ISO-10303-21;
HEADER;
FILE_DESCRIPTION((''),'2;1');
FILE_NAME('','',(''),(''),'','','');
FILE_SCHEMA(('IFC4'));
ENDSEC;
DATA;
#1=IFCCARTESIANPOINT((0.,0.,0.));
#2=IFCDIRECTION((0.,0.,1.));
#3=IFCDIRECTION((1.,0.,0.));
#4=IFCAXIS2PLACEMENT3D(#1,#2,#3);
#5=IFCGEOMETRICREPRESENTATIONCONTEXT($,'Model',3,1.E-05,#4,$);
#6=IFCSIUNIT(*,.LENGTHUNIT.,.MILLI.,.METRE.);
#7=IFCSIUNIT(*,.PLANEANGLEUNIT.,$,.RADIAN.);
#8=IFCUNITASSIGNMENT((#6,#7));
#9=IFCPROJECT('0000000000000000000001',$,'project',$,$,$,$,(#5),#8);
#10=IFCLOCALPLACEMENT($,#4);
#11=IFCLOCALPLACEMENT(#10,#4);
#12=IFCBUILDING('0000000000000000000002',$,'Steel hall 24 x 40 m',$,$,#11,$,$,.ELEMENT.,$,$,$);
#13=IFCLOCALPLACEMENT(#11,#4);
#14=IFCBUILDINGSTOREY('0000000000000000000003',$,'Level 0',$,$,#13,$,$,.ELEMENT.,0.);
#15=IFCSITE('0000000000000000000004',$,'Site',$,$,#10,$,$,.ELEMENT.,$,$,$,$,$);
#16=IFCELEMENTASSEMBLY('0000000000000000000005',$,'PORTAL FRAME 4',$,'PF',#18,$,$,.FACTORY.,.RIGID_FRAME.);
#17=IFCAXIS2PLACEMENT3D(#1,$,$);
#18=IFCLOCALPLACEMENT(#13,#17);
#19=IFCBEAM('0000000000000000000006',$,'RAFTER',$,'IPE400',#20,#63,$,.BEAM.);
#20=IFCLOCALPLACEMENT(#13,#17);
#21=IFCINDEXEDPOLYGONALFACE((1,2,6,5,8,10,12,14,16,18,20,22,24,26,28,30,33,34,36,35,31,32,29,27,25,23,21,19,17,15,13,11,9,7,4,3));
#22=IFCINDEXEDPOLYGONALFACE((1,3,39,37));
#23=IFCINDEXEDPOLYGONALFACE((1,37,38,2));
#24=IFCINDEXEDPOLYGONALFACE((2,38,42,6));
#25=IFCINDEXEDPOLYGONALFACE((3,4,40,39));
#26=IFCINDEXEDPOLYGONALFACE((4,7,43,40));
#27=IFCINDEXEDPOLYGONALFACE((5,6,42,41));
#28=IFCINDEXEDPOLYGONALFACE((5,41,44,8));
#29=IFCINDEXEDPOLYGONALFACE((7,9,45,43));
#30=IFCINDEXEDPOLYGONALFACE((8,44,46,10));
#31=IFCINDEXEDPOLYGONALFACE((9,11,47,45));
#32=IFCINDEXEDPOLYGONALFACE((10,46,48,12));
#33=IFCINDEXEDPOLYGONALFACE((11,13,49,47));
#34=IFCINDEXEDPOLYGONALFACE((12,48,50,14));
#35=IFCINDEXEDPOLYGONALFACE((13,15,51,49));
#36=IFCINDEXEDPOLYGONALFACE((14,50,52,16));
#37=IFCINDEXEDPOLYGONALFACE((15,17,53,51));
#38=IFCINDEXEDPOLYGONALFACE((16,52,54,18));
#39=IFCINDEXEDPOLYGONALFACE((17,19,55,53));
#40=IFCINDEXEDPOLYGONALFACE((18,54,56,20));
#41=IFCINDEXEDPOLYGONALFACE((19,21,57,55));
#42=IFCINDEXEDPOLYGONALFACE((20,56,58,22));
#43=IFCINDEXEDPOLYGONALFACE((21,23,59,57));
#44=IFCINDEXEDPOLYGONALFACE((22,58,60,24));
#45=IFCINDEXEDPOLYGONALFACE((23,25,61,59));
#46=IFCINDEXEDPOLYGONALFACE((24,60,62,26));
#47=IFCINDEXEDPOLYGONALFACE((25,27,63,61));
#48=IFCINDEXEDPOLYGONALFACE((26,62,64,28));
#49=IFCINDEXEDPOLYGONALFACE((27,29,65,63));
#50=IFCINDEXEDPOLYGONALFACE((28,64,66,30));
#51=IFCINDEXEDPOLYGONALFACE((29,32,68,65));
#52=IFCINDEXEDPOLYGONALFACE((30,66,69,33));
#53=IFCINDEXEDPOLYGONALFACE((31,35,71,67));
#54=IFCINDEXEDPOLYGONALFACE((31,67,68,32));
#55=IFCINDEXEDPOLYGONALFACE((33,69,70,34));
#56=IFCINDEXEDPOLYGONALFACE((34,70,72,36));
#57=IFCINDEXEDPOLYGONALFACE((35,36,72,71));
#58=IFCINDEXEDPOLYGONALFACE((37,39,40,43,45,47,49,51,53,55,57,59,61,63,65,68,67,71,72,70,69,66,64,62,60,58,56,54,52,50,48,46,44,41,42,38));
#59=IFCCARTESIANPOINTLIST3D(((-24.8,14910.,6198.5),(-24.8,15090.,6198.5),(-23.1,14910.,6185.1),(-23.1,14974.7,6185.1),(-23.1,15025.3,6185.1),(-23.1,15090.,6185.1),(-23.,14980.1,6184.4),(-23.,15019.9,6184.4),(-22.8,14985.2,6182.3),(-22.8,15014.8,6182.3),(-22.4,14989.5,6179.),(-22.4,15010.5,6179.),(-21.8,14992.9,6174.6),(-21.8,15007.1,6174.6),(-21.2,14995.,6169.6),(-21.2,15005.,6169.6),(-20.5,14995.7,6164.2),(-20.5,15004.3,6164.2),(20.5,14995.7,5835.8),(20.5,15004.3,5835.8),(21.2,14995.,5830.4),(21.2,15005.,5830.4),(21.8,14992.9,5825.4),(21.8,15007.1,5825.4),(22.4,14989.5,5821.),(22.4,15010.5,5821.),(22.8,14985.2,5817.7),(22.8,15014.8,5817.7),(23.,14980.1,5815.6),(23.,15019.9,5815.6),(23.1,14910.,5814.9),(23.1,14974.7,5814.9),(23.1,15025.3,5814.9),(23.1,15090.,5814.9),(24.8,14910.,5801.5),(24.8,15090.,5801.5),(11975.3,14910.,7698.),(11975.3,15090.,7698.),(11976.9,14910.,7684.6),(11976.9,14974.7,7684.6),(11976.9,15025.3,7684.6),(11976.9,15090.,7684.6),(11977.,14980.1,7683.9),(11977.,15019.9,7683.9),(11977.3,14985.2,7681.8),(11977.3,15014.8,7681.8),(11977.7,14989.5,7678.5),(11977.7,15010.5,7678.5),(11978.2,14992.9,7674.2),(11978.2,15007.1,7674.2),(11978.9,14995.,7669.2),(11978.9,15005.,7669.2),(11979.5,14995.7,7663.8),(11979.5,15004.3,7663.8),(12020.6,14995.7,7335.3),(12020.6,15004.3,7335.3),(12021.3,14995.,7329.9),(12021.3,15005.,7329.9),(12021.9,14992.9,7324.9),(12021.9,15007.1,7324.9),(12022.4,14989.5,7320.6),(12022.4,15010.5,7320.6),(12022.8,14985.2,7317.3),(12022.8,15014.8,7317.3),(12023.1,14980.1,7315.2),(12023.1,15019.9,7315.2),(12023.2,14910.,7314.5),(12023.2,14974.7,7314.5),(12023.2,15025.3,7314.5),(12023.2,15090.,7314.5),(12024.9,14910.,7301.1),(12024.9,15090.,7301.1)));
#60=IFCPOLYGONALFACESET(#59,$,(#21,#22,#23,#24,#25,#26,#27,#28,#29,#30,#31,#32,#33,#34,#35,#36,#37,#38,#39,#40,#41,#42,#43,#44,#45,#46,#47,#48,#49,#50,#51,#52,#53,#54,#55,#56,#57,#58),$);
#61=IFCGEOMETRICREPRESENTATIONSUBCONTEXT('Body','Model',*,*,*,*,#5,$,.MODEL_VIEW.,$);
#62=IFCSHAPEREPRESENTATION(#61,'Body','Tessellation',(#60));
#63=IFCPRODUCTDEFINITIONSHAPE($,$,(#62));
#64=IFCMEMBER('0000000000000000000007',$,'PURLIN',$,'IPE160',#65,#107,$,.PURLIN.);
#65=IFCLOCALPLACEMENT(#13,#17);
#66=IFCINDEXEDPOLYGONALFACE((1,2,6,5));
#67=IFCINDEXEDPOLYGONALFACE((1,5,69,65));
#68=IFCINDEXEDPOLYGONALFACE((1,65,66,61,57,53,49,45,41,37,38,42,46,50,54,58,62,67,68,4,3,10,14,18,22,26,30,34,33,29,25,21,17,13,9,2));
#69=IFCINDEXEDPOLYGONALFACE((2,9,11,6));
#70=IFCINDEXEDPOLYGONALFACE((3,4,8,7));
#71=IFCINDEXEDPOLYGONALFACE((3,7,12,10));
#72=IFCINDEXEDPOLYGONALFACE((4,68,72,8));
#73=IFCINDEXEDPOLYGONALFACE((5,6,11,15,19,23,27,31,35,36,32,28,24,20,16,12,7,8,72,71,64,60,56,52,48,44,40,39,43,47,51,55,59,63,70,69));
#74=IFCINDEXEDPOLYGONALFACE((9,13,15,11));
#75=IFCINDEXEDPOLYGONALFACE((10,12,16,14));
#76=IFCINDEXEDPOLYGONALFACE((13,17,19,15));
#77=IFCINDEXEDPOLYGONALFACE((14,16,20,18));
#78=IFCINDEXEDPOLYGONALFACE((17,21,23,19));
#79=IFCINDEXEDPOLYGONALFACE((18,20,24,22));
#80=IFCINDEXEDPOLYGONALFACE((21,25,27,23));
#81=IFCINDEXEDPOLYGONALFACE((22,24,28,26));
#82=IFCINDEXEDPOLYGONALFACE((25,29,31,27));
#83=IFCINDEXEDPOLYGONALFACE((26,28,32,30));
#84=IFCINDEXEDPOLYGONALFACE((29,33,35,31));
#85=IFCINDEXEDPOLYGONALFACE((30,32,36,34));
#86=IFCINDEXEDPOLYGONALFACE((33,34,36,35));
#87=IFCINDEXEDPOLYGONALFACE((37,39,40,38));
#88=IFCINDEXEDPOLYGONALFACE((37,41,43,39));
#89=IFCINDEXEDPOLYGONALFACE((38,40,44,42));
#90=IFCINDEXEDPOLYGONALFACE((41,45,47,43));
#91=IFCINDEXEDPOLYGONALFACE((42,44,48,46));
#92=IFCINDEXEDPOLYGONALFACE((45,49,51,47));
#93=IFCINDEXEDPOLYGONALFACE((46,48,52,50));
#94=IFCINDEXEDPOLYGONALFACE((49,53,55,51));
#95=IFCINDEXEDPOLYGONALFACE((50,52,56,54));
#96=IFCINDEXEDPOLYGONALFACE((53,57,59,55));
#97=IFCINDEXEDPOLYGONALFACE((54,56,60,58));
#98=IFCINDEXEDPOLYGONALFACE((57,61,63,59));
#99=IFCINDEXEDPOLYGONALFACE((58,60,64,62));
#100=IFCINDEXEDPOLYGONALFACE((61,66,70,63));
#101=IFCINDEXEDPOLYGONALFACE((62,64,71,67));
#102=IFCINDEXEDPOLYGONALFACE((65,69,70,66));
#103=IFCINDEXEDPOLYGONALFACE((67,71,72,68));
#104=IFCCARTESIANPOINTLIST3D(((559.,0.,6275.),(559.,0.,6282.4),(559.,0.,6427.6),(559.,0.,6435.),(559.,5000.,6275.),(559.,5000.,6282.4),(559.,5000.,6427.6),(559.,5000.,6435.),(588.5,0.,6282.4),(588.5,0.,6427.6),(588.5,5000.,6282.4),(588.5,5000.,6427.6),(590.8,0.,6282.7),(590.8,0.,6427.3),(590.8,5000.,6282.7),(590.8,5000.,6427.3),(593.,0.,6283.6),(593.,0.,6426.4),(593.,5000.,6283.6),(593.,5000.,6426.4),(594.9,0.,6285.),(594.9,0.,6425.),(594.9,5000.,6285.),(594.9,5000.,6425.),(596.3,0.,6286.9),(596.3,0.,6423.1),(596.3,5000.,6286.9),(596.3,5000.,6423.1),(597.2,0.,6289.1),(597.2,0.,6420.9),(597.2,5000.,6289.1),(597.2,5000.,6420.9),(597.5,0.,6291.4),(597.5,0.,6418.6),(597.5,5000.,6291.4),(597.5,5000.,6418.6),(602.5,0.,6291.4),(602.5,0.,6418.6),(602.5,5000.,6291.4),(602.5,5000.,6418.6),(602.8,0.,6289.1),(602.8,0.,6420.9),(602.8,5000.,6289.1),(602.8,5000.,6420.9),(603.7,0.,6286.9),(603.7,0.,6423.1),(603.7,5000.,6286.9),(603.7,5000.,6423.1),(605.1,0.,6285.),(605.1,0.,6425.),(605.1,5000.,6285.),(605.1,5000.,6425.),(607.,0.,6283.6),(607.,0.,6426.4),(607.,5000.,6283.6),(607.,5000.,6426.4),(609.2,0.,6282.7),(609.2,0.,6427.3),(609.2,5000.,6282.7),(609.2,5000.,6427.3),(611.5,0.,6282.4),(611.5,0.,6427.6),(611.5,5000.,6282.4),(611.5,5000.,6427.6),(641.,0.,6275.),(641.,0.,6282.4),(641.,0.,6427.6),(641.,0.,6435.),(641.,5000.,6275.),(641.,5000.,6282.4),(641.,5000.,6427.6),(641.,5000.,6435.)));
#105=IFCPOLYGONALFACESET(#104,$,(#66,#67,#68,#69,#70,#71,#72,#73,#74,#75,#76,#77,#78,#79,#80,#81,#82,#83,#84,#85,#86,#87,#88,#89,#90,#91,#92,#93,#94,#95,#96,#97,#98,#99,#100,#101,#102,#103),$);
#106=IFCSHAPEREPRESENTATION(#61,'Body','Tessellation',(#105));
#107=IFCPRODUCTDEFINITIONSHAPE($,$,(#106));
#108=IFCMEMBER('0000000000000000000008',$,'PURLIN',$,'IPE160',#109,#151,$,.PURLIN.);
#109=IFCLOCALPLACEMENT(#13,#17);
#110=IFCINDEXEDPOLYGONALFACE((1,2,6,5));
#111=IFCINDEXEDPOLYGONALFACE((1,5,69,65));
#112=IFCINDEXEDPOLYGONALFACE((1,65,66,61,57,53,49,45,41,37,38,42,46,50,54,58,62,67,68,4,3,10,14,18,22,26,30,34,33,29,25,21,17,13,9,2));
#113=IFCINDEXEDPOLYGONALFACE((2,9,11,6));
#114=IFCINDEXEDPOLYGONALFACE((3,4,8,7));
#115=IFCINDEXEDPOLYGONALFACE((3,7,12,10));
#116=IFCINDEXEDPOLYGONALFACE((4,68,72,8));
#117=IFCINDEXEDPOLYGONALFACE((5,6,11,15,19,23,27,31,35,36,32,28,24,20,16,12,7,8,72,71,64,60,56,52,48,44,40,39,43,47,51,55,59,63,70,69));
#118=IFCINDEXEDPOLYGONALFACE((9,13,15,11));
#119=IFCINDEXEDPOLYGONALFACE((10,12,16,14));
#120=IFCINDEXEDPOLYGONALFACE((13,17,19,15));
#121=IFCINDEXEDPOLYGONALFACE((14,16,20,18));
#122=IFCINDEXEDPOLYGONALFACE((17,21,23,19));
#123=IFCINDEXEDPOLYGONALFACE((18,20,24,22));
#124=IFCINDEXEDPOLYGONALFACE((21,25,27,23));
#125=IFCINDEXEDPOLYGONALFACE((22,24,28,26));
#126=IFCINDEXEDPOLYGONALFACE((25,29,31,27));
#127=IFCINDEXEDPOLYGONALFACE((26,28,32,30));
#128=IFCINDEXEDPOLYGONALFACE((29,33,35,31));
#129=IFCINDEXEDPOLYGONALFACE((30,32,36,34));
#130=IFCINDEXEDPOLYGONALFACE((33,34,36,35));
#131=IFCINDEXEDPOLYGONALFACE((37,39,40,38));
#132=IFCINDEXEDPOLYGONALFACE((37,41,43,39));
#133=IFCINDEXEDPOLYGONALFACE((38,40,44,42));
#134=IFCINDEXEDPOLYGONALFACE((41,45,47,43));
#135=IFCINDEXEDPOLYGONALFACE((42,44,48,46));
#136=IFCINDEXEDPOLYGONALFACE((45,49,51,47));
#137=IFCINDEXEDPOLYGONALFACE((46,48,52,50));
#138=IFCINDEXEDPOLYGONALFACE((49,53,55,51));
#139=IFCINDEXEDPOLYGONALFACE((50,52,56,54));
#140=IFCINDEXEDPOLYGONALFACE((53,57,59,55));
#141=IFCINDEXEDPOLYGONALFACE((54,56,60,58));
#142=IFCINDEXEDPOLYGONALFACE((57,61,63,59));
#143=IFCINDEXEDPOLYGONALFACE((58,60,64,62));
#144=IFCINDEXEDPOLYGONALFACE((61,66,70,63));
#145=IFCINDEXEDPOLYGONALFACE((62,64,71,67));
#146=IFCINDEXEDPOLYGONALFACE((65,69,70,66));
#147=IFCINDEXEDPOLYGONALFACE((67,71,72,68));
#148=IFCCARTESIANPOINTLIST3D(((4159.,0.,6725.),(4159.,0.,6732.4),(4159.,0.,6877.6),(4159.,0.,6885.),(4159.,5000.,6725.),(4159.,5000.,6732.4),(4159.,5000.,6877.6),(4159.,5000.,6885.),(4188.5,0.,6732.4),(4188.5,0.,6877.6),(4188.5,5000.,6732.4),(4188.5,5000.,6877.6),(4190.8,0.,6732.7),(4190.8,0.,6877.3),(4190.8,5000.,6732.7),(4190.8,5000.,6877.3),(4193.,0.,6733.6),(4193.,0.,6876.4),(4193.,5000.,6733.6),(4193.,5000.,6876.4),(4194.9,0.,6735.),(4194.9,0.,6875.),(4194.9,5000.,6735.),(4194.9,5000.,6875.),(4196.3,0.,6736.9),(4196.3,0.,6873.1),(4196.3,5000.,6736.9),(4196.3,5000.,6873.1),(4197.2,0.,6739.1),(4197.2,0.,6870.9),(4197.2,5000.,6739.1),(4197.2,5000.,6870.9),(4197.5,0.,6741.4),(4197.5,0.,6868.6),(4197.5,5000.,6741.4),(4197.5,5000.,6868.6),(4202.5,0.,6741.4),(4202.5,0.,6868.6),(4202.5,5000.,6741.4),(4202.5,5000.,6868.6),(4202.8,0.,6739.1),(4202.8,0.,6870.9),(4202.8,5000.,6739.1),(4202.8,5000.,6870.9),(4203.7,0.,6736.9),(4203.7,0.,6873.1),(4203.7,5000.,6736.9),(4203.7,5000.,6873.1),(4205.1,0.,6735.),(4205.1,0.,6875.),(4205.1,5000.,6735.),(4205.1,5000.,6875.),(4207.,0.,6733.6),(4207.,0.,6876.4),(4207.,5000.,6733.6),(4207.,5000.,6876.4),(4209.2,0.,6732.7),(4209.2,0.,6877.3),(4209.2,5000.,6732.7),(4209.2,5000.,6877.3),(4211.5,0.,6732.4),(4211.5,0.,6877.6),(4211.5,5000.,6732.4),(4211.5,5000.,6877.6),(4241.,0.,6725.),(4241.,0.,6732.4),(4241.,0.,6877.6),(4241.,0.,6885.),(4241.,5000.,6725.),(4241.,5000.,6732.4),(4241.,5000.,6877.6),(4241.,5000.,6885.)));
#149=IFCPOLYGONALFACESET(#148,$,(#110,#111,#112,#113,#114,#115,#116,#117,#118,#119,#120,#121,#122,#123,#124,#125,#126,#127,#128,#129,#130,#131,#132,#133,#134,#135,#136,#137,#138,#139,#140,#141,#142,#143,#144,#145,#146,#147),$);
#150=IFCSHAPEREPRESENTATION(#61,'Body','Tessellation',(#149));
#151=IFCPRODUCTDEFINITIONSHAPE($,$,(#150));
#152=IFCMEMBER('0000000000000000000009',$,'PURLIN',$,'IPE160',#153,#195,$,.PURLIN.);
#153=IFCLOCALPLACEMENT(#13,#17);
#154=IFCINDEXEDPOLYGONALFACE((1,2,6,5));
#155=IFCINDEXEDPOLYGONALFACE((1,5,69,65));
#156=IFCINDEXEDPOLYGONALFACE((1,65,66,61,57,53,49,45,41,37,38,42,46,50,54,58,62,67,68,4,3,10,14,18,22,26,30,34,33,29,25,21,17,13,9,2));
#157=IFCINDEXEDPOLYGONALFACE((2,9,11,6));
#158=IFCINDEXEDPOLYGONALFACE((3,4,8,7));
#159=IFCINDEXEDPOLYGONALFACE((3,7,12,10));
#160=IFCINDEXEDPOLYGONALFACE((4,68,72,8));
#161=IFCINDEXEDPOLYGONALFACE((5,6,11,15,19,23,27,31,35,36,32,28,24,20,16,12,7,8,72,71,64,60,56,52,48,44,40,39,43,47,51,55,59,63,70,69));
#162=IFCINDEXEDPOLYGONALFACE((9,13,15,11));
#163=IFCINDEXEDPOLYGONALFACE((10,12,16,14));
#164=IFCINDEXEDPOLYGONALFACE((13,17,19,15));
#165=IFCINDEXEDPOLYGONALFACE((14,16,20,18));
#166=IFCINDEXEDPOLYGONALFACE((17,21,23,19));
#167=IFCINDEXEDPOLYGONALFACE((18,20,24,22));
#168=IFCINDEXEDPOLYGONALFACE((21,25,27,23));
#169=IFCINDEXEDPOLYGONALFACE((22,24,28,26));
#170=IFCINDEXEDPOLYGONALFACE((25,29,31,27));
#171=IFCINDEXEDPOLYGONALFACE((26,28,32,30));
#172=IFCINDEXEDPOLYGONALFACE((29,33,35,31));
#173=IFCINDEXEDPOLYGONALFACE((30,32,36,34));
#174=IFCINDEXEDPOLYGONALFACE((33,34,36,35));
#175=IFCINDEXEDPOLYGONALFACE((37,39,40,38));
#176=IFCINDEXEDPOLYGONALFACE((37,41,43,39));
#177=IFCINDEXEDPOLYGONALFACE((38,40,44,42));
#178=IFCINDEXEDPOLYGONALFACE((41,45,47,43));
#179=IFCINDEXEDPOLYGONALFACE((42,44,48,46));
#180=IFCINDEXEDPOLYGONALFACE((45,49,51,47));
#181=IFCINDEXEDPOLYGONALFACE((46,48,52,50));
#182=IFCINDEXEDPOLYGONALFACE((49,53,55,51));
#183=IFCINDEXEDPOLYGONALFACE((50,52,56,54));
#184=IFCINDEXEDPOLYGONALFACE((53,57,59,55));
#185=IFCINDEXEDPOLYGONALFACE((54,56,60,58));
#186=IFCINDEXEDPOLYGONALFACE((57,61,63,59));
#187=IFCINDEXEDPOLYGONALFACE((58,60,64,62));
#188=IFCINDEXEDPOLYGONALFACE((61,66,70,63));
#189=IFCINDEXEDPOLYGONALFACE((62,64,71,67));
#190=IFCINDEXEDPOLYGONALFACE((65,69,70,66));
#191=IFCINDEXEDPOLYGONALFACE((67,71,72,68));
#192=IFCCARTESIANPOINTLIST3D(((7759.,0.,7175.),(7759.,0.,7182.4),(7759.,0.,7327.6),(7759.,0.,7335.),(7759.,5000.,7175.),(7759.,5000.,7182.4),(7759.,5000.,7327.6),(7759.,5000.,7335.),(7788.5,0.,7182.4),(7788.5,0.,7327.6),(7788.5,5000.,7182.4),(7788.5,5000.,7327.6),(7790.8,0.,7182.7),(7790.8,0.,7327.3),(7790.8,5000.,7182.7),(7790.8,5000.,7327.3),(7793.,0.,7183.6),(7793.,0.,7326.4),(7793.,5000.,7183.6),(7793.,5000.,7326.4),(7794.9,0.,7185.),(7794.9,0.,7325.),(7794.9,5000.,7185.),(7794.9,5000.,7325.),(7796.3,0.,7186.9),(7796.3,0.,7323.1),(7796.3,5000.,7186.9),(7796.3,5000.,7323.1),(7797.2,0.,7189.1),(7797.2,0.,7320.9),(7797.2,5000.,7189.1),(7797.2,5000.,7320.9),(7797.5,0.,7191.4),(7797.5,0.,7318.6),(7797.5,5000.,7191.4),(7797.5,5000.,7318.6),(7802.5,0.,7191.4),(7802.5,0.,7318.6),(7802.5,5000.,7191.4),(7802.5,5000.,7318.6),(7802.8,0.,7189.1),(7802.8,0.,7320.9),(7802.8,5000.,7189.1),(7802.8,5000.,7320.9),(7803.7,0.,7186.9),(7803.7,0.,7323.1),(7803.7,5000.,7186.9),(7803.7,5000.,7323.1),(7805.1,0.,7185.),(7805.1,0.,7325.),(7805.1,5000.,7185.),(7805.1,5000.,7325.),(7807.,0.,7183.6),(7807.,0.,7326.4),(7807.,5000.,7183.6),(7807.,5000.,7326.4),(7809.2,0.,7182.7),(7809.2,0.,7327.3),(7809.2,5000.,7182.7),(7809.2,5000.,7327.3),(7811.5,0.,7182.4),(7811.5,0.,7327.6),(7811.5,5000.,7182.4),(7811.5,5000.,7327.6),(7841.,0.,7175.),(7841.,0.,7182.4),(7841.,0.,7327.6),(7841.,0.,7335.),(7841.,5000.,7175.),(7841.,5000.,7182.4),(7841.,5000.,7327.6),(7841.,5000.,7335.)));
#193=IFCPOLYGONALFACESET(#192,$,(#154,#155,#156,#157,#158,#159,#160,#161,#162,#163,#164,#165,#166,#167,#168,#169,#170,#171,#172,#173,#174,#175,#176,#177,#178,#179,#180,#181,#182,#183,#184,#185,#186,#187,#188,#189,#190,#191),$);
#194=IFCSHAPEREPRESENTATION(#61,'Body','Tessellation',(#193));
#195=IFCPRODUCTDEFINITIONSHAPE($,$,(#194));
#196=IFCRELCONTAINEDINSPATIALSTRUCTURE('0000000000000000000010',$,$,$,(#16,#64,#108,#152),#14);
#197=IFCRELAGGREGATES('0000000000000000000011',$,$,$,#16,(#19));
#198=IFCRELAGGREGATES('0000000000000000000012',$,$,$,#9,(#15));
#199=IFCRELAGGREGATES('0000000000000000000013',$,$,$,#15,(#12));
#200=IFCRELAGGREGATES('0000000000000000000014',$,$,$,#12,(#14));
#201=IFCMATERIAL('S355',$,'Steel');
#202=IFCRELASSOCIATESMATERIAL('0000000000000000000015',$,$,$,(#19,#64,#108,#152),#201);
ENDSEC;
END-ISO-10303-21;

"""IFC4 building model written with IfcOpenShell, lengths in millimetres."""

from ifc_helpers import new_model, si_unit, frame, origin_with_axes, place, context, subcontext, project, spatial, i_section, extrude, material, element, aggregate, save


model = new_model("IFC4")

# Units and contexts
model_context = context("Model", 3, precision=1e-05, world=origin_with_axes())
body_context = subcontext(model_context, "Body", "Model", "MODEL_VIEW")
ifc_project = project(units=[si_unit("LENGTHUNIT", "METRE", prefix="MILLI"), si_unit("PLANEANGLEUNIT", "RADIAN")], contexts=[model_context])

# Site, building, storey
site_placement = place(None, origin_with_axes())
site = spatial("IfcSite", under=ifc_project, at=site_placement, Name="Site", CompositionType="ELEMENT")
building_placement = place(site_placement, origin_with_axes())
building = spatial("IfcBuilding", under=site, at=building_placement, Name="Steel hall 24 x 40 m", CompositionType="ELEMENT")
storey_placement = place(building_placement, origin_with_axes())
storey = spatial("IfcBuildingStorey", under=building, at=storey_placement, Name="Level 0", CompositionType="ELEMENT", Elevation=0.0)

# Element assembly
ifc_material = material(Name="S355", Category="Steel")
assembly_1_placement = place(storey_placement, frame((0.0, 15000.0, 0.0), z_axis=(0.0, 0.0, 1.0), x_axis=(1.0, 0.0, 0.0)))
assembly_1 = element("IfcElementAssembly", 1, at=assembly_1_placement, inside=storey, Name="PORTAL FRAME 4", ObjectType="PF", AssemblyPlace="FACTORY", PredefinedType="RIGID_FRAME")

# Beam
beam_1_placement = place(storey_placement, frame((0.0, 15000.0, 6000.0), z_axis=(0.9923, 0.0, 0.124), x_axis=(0.0, 1.0, 0.0)))
beam_1 = element("IfcBeam", 2, at=beam_1_placement, material=ifc_material, Name="RAFTER", ObjectType="IPE400", PredefinedType="BEAM", context=body_context, shape_type="SweptSolid", body=[
    extrude(i_section(OverallWidth=180.0, OverallDepth=400.0, WebThickness=8.6, FlangeThickness=13.5, FilletRadius=21.0), origin_with_axes(), (0.0, 0.0, 1.0), 12093.4),
])

# Members
for number, where, z_axis, x_axis, name in (
    (3, (600.0, 0.0, 6355.0), (0.0, 1.0, 0.0), (1.0, 0.0, 0.0), "PURLIN"),
    (4, (4200.0, 0.0, 6805.0), (0.0, 1.0, 0.0), (1.0, 0.0, 0.0), "PURLIN"),
    (5, (7800.0, 0.0, 7255.0), (0.0, 1.0, 0.0), (1.0, 0.0, 0.0), "PURLIN"),
):
    element("IfcMember", number, at=place(storey_placement, frame(where, z_axis=z_axis, x_axis=x_axis)), inside=storey, material=ifc_material, Name=name, ObjectType="IPE160", PredefinedType="PURLIN", context=body_context, shape_type="SweptSolid", body=[
        extrude(i_section(OverallWidth=82.0, OverallDepth=160.0, WebThickness=5.0, FlangeThickness=7.4, FilletRadius=9.0), origin_with_axes(), (0.0, 0.0, 1.0), 5000.0),
    ])

aggregate(assembly_1, [beam_1])

save(model, "model.ifc")
